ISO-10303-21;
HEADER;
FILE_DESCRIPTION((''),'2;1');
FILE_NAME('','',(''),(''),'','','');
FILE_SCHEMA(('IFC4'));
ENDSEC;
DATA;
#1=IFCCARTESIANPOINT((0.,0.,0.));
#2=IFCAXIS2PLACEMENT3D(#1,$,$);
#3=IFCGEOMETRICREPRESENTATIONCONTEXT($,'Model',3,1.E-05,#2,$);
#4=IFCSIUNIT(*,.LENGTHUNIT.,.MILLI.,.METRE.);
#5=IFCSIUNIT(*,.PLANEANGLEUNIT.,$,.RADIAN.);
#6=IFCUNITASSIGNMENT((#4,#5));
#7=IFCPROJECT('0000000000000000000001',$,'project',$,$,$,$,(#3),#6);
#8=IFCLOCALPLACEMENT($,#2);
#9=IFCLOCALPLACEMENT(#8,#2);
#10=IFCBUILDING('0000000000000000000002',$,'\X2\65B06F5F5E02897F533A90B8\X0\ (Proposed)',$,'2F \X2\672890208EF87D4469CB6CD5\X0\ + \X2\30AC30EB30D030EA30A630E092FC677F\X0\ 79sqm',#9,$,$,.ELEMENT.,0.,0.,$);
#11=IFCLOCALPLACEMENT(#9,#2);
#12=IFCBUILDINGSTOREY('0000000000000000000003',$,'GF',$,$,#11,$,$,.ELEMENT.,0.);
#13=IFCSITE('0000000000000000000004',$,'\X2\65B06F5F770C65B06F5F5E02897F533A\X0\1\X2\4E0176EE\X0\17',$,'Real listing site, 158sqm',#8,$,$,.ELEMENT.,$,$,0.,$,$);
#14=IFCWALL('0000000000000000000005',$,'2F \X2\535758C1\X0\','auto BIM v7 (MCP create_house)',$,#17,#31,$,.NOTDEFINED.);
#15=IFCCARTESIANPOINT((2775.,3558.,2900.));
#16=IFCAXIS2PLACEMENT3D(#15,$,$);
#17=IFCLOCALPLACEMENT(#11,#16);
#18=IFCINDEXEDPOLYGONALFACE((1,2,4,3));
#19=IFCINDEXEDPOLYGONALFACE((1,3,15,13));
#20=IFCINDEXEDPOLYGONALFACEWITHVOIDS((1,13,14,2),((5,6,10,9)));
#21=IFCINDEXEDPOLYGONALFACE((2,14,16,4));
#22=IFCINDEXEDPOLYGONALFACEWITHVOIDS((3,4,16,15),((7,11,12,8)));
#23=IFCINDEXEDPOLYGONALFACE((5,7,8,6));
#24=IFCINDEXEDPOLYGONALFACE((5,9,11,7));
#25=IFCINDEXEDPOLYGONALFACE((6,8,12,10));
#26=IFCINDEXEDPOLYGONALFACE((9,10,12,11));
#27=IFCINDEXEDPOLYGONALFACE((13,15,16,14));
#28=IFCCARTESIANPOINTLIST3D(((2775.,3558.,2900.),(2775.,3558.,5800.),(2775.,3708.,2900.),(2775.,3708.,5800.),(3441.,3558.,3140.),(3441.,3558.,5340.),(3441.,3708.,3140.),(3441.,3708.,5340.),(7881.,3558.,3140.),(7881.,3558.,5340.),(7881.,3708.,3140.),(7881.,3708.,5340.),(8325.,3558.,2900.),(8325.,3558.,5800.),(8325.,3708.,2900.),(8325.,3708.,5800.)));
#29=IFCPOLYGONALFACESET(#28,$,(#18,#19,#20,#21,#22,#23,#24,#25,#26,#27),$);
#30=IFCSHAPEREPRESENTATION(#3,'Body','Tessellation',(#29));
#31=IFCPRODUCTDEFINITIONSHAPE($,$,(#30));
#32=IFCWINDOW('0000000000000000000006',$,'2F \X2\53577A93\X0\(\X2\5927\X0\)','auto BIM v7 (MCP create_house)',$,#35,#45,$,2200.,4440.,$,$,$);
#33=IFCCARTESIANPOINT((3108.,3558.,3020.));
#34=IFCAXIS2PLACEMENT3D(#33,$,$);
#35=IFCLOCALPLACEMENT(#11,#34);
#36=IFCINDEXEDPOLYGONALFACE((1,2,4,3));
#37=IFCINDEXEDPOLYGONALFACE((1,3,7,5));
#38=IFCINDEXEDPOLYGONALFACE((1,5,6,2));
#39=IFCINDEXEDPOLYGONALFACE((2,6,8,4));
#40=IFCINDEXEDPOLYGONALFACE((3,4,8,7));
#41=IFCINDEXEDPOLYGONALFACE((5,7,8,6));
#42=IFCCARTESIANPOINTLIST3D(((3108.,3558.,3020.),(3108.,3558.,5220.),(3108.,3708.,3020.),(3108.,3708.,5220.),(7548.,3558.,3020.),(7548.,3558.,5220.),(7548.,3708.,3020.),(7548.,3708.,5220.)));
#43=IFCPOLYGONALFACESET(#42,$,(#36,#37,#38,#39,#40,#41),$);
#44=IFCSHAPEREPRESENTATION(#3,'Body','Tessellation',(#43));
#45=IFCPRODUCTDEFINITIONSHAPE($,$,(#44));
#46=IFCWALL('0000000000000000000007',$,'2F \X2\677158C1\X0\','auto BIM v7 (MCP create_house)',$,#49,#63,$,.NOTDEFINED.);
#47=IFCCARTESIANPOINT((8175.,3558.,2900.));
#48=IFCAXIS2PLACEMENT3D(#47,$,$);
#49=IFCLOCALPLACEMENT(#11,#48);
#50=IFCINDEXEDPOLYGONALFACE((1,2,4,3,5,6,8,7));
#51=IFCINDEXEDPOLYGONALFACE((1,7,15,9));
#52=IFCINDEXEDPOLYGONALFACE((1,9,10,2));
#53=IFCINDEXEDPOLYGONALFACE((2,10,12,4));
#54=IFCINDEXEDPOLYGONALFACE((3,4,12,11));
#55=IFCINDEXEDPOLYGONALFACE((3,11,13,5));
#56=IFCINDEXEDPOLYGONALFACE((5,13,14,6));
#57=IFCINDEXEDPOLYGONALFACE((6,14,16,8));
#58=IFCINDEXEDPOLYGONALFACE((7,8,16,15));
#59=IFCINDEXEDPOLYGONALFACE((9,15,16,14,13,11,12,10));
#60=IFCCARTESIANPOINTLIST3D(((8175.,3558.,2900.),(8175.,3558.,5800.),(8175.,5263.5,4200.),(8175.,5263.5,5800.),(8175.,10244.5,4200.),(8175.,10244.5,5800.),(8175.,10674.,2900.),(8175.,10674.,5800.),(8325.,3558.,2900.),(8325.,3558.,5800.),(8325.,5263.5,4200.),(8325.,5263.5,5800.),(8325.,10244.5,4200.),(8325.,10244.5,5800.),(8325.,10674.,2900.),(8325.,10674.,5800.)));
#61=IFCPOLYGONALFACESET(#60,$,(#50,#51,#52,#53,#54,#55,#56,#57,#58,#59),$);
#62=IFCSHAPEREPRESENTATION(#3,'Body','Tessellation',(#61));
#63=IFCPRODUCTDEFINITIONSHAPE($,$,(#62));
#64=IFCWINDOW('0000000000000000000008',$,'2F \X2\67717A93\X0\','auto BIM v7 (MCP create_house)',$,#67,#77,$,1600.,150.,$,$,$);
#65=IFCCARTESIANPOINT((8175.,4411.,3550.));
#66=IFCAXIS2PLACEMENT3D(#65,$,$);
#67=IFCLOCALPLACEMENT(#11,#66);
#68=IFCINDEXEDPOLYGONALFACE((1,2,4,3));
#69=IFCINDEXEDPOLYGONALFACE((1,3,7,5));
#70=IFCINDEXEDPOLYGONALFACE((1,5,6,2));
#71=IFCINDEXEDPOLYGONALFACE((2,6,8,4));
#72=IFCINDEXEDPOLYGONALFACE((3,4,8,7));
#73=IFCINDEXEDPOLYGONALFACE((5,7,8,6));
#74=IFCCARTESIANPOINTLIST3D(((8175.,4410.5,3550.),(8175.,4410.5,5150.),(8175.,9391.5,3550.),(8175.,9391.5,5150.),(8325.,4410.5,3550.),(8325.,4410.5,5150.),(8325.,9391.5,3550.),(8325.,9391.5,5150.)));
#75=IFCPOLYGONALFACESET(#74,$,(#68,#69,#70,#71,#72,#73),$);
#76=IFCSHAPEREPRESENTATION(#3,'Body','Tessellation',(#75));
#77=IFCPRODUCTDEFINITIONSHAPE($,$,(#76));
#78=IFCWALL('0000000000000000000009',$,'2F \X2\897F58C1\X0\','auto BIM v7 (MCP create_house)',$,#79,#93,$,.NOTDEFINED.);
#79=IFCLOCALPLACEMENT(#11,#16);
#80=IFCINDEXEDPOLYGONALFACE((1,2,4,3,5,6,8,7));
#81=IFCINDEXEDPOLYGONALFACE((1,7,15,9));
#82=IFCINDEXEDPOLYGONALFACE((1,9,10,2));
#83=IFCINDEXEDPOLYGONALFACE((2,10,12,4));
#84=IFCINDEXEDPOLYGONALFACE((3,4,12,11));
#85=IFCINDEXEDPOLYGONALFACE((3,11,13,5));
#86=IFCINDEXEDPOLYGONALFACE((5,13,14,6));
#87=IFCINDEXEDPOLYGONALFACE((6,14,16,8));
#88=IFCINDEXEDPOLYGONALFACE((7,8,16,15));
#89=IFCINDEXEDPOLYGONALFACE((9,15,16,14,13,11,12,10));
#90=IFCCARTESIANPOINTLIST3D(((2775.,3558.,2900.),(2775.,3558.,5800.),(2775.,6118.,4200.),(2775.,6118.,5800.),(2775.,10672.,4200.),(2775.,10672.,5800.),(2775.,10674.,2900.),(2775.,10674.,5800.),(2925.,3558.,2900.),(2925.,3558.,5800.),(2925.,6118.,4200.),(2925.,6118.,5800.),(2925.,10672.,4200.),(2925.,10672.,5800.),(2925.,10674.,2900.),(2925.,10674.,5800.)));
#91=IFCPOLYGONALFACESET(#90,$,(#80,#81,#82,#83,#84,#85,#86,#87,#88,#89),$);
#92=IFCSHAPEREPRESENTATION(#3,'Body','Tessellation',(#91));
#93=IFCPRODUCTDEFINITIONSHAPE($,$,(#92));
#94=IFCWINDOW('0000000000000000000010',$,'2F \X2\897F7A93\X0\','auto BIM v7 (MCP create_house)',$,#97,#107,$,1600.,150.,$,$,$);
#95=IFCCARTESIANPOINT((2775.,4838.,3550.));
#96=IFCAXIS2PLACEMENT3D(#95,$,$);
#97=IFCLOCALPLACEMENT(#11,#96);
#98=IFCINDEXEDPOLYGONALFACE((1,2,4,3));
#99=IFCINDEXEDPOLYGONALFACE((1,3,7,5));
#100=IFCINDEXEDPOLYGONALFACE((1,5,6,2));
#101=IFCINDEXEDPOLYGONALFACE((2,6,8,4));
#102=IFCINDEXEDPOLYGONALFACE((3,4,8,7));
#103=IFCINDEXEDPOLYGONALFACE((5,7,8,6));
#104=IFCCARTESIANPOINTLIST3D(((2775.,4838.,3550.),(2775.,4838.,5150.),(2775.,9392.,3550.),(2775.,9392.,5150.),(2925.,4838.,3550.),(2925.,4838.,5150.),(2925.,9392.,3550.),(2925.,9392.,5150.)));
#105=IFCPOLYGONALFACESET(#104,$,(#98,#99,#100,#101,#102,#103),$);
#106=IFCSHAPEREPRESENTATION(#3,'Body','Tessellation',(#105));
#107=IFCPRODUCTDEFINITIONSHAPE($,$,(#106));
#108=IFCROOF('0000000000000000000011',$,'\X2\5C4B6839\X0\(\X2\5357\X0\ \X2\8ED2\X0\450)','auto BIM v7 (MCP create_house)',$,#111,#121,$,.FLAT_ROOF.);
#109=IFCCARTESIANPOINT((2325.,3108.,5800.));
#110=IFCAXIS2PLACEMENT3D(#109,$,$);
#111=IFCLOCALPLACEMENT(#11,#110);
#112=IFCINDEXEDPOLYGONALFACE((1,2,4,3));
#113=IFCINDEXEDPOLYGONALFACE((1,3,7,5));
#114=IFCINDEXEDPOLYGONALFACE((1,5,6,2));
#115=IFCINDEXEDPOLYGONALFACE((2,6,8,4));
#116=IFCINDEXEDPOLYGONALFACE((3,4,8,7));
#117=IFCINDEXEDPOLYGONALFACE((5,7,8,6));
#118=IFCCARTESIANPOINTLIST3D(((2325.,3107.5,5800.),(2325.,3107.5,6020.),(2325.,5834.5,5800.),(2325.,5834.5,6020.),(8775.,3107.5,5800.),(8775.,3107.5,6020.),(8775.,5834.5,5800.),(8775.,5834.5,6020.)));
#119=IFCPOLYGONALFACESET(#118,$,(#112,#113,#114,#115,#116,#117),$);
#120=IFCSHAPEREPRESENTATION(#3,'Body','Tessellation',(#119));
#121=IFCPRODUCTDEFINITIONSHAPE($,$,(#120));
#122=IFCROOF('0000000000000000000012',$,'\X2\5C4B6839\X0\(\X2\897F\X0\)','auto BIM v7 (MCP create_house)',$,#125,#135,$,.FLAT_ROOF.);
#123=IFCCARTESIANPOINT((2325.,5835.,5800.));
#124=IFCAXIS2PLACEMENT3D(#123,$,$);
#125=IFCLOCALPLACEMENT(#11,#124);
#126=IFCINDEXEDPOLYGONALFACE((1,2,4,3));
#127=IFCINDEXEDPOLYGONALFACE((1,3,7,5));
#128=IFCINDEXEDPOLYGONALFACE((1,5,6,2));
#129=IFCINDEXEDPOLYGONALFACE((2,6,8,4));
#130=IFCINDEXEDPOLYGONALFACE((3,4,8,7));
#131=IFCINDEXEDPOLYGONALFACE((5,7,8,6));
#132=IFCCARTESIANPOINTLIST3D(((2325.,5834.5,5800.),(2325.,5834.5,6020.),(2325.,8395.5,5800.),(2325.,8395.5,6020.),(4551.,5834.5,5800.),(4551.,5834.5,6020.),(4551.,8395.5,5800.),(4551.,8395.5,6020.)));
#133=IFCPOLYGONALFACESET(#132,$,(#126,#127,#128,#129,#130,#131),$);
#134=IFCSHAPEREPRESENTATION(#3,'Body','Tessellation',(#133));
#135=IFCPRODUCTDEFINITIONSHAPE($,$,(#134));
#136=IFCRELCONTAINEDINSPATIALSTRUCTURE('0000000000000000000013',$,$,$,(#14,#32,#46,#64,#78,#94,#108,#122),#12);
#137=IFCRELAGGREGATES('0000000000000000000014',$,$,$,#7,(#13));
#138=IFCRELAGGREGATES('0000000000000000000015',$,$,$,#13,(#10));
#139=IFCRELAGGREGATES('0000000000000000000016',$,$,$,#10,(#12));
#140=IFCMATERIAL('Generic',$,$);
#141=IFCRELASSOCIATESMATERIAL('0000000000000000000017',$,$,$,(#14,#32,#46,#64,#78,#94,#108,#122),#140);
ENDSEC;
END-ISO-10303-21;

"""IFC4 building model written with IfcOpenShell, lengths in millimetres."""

from ifc_helpers import new_model, si_unit, frame, frame_2d, origin, place, context, project, spatial, rectangle, extrude, material, element, fill, save


model = new_model("IFC4")

# Units and contexts
model_context = context("Model", 3, precision=1e-05, world=origin())
ifc_project = project(units=[si_unit("LENGTHUNIT", "METRE", prefix="MILLI"), si_unit("PLANEANGLEUNIT", "RADIAN")], contexts=[model_context])

# Site, building, storey
site_placement = place(None, origin())
site = spatial("IfcSite", under=ifc_project, at=site_placement, Name="新潟県新潟市西区1丁目17", ObjectType="Real listing site, 158sqm", CompositionType="ELEMENT", RefElevation=0.0)
building_placement = place(site_placement, origin())
building = spatial("IfcBuilding", under=site, at=building_placement, Name="新潟市西区邸 (Proposed)", ObjectType="2F 木造軸組構法 + ガルバリウム鋼板 79sqm", CompositionType="ELEMENT", ElevationOfRefHeight=0.0, ElevationOfTerrain=0.0)
storey_placement = place(building_placement, origin())
storey = spatial("IfcBuildingStorey", under=building, at=storey_placement, Name="GF", CompositionType="ELEMENT", Elevation=0.0)

# Shared definitions
ifc_material = material(Name="Generic")

# Walls, openings, windows
wall_1_placement = place(storey_placement, frame((2775.0, 3558.0, 2900.0)))
wall_1 = element("IfcWall", 1, at=wall_1_placement, inside=storey, material=ifc_material, Name="2F 南壁", Description="auto BIM v7 (MCP create_house)", PredefinedType="NOTDEFINED", context=model_context, shape_type="SweptSolid", body=[
    extrude(rectangle(XDim=5550.0, YDim=150.0, at=frame_2d((2775.0, 75.0))), frame((2775.0, 3558.0, 2900.0)), (0.0, 0.0, 1.0), 2900.0),
])
opening_1_placement = place(storey_placement, frame((3108.0, 3558.0, 3020.0)))
opening_1 = element("IfcOpeningElement", 2, at=opening_1_placement, cuts=wall_1, PredefinedType="NOTDEFINED", context=model_context, shape_type="SweptSolid", body=[
    extrude(rectangle(XDim=4440.0, YDim=150.0, at=frame_2d((2220.0, 75.0))), frame((3108.0, 3558.0, 3020.0)), (0.0, 0.0, 1.0), 2200.0),
])
window_1_placement = place(storey_placement, frame((3108.0, 3558.0, 3020.0)))
window_1 = element("IfcWindow", 3, at=window_1_placement, inside=storey, material=ifc_material, Name="2F 南窓(大)", Description="auto BIM v7 (MCP create_house)", OverallHeight=2200.0, OverallWidth=4440.0, context=model_context, shape_type="SweptSolid", body=[
    extrude(rectangle(XDim=4440.0, YDim=150.0, at=frame_2d((2220.0, 75.0))), frame((3108.0, 3558.0, 3020.0)), (0.0, 0.0, 1.0), 2200.0),
])
fill(opening_1, window_1)
wall_2_placement = place(storey_placement, frame((8175.0, 3558.0, 2900.0)))
wall_2 = element("IfcWall", 4, at=wall_2_placement, inside=storey, material=ifc_material, Name="2F 東壁", Description="auto BIM v7 (MCP create_house)", PredefinedType="NOTDEFINED", context=model_context, shape_type="SweptSolid", body=[
    extrude(rectangle(XDim=150.0, YDim=7116.0, at=frame_2d((75.0, 3558.0))), frame((8175.0, 3558.0, 2900.0)), (0.0, 0.0, 1.0), 2900.0),
])
opening_2_placement = place(storey_placement, frame((8175.0, 4411.0, 3550.0)))
opening_2 = element("IfcOpeningElement", 5, at=opening_2_placement, cuts=wall_2, PredefinedType="NOTDEFINED", context=model_context, shape_type="SweptSolid", body=[
    extrude(rectangle(XDim=150.0, YDim=4981.0, at=frame_2d((75.0, 2490.0))), frame((8175.0, 4411.0, 3550.0)), (0.0, 0.0, 1.0), 1600.0),
])
window_2_placement = place(storey_placement, frame((8175.0, 4411.0, 3550.0)))
window_2 = element("IfcWindow", 6, at=window_2_placement, inside=storey, material=ifc_material, Name="2F 東窓", Description="auto BIM v7 (MCP create_house)", OverallHeight=1600.0, OverallWidth=150.0, context=model_context, shape_type="SweptSolid", body=[
    extrude(rectangle(XDim=150.0, YDim=4981.0, at=frame_2d((75.0, 2490.0))), frame((8175.0, 4411.0, 3550.0)), (0.0, 0.0, 1.0), 1600.0),
])
fill(opening_2, window_2)
wall_3_placement = place(storey_placement, frame((2775.0, 3558.0, 2900.0)))
wall_3 = element("IfcWall", 7, at=wall_3_placement, inside=storey, material=ifc_material, Name="2F 西壁", Description="auto BIM v7 (MCP create_house)", PredefinedType="NOTDEFINED", context=model_context, shape_type="SweptSolid", body=[
    extrude(rectangle(XDim=150.0, YDim=7116.0, at=frame_2d((75.0, 3558.0))), frame((2775.0, 3558.0, 2900.0)), (0.0, 0.0, 1.0), 2900.0),
])
opening_3_placement = place(storey_placement, frame((2775.0, 4838.0, 3550.0)))
opening_3 = element("IfcOpeningElement", 8, at=opening_3_placement, cuts=wall_3, PredefinedType="NOTDEFINED", context=model_context, shape_type="SweptSolid", body=[
    extrude(rectangle(XDim=150.0, YDim=4554.0, at=frame_2d((75.0, 2277.0))), frame((2775.0, 4838.0, 3550.0)), (0.0, 0.0, 1.0), 1600.0),
])
window_3_placement = place(storey_placement, frame((2775.0, 4838.0, 3550.0)))
window_3 = element("IfcWindow", 9, at=window_3_placement, inside=storey, material=ifc_material, Name="2F 西窓", Description="auto BIM v7 (MCP create_house)", OverallHeight=1600.0, OverallWidth=150.0, context=model_context, shape_type="SweptSolid", body=[
    extrude(rectangle(XDim=150.0, YDim=4554.0, at=frame_2d((75.0, 2277.0))), frame((2775.0, 4838.0, 3550.0)), (0.0, 0.0, 1.0), 1600.0),
])
fill(opening_3, window_3)

# Roofs
roof_1_placement = place(storey_placement, frame((2325.0, 3108.0, 5800.0)))
element("IfcRoof", 10, at=roof_1_placement, inside=storey, material=ifc_material, Name="屋根(南 軒450)", Description="auto BIM v7 (MCP create_house)", PredefinedType="FLAT_ROOF", context=model_context, shape_type="SweptSolid", body=[
    extrude(rectangle(XDim=6450.0, YDim=2727.0, at=frame_2d((3225.0, 1363.0))), frame((2325.0, 3108.0, 5800.0)), (0.0, 0.0, 1.0), 220.0),
])
roof_2_placement = place(storey_placement, frame((2325.0, 5835.0, 5800.0)))
element("IfcRoof", 11, at=roof_2_placement, inside=storey, material=ifc_material, Name="屋根(西)", Description="auto BIM v7 (MCP create_house)", PredefinedType="FLAT_ROOF", context=model_context, shape_type="SweptSolid", body=[
    extrude(rectangle(XDim=2226.0, YDim=2561.0, at=frame_2d((1113.0, 1280.0))), frame((2325.0, 5835.0, 5800.0)), (0.0, 0.0, 1.0), 220.0),
])

save(model, "model.ifc")
